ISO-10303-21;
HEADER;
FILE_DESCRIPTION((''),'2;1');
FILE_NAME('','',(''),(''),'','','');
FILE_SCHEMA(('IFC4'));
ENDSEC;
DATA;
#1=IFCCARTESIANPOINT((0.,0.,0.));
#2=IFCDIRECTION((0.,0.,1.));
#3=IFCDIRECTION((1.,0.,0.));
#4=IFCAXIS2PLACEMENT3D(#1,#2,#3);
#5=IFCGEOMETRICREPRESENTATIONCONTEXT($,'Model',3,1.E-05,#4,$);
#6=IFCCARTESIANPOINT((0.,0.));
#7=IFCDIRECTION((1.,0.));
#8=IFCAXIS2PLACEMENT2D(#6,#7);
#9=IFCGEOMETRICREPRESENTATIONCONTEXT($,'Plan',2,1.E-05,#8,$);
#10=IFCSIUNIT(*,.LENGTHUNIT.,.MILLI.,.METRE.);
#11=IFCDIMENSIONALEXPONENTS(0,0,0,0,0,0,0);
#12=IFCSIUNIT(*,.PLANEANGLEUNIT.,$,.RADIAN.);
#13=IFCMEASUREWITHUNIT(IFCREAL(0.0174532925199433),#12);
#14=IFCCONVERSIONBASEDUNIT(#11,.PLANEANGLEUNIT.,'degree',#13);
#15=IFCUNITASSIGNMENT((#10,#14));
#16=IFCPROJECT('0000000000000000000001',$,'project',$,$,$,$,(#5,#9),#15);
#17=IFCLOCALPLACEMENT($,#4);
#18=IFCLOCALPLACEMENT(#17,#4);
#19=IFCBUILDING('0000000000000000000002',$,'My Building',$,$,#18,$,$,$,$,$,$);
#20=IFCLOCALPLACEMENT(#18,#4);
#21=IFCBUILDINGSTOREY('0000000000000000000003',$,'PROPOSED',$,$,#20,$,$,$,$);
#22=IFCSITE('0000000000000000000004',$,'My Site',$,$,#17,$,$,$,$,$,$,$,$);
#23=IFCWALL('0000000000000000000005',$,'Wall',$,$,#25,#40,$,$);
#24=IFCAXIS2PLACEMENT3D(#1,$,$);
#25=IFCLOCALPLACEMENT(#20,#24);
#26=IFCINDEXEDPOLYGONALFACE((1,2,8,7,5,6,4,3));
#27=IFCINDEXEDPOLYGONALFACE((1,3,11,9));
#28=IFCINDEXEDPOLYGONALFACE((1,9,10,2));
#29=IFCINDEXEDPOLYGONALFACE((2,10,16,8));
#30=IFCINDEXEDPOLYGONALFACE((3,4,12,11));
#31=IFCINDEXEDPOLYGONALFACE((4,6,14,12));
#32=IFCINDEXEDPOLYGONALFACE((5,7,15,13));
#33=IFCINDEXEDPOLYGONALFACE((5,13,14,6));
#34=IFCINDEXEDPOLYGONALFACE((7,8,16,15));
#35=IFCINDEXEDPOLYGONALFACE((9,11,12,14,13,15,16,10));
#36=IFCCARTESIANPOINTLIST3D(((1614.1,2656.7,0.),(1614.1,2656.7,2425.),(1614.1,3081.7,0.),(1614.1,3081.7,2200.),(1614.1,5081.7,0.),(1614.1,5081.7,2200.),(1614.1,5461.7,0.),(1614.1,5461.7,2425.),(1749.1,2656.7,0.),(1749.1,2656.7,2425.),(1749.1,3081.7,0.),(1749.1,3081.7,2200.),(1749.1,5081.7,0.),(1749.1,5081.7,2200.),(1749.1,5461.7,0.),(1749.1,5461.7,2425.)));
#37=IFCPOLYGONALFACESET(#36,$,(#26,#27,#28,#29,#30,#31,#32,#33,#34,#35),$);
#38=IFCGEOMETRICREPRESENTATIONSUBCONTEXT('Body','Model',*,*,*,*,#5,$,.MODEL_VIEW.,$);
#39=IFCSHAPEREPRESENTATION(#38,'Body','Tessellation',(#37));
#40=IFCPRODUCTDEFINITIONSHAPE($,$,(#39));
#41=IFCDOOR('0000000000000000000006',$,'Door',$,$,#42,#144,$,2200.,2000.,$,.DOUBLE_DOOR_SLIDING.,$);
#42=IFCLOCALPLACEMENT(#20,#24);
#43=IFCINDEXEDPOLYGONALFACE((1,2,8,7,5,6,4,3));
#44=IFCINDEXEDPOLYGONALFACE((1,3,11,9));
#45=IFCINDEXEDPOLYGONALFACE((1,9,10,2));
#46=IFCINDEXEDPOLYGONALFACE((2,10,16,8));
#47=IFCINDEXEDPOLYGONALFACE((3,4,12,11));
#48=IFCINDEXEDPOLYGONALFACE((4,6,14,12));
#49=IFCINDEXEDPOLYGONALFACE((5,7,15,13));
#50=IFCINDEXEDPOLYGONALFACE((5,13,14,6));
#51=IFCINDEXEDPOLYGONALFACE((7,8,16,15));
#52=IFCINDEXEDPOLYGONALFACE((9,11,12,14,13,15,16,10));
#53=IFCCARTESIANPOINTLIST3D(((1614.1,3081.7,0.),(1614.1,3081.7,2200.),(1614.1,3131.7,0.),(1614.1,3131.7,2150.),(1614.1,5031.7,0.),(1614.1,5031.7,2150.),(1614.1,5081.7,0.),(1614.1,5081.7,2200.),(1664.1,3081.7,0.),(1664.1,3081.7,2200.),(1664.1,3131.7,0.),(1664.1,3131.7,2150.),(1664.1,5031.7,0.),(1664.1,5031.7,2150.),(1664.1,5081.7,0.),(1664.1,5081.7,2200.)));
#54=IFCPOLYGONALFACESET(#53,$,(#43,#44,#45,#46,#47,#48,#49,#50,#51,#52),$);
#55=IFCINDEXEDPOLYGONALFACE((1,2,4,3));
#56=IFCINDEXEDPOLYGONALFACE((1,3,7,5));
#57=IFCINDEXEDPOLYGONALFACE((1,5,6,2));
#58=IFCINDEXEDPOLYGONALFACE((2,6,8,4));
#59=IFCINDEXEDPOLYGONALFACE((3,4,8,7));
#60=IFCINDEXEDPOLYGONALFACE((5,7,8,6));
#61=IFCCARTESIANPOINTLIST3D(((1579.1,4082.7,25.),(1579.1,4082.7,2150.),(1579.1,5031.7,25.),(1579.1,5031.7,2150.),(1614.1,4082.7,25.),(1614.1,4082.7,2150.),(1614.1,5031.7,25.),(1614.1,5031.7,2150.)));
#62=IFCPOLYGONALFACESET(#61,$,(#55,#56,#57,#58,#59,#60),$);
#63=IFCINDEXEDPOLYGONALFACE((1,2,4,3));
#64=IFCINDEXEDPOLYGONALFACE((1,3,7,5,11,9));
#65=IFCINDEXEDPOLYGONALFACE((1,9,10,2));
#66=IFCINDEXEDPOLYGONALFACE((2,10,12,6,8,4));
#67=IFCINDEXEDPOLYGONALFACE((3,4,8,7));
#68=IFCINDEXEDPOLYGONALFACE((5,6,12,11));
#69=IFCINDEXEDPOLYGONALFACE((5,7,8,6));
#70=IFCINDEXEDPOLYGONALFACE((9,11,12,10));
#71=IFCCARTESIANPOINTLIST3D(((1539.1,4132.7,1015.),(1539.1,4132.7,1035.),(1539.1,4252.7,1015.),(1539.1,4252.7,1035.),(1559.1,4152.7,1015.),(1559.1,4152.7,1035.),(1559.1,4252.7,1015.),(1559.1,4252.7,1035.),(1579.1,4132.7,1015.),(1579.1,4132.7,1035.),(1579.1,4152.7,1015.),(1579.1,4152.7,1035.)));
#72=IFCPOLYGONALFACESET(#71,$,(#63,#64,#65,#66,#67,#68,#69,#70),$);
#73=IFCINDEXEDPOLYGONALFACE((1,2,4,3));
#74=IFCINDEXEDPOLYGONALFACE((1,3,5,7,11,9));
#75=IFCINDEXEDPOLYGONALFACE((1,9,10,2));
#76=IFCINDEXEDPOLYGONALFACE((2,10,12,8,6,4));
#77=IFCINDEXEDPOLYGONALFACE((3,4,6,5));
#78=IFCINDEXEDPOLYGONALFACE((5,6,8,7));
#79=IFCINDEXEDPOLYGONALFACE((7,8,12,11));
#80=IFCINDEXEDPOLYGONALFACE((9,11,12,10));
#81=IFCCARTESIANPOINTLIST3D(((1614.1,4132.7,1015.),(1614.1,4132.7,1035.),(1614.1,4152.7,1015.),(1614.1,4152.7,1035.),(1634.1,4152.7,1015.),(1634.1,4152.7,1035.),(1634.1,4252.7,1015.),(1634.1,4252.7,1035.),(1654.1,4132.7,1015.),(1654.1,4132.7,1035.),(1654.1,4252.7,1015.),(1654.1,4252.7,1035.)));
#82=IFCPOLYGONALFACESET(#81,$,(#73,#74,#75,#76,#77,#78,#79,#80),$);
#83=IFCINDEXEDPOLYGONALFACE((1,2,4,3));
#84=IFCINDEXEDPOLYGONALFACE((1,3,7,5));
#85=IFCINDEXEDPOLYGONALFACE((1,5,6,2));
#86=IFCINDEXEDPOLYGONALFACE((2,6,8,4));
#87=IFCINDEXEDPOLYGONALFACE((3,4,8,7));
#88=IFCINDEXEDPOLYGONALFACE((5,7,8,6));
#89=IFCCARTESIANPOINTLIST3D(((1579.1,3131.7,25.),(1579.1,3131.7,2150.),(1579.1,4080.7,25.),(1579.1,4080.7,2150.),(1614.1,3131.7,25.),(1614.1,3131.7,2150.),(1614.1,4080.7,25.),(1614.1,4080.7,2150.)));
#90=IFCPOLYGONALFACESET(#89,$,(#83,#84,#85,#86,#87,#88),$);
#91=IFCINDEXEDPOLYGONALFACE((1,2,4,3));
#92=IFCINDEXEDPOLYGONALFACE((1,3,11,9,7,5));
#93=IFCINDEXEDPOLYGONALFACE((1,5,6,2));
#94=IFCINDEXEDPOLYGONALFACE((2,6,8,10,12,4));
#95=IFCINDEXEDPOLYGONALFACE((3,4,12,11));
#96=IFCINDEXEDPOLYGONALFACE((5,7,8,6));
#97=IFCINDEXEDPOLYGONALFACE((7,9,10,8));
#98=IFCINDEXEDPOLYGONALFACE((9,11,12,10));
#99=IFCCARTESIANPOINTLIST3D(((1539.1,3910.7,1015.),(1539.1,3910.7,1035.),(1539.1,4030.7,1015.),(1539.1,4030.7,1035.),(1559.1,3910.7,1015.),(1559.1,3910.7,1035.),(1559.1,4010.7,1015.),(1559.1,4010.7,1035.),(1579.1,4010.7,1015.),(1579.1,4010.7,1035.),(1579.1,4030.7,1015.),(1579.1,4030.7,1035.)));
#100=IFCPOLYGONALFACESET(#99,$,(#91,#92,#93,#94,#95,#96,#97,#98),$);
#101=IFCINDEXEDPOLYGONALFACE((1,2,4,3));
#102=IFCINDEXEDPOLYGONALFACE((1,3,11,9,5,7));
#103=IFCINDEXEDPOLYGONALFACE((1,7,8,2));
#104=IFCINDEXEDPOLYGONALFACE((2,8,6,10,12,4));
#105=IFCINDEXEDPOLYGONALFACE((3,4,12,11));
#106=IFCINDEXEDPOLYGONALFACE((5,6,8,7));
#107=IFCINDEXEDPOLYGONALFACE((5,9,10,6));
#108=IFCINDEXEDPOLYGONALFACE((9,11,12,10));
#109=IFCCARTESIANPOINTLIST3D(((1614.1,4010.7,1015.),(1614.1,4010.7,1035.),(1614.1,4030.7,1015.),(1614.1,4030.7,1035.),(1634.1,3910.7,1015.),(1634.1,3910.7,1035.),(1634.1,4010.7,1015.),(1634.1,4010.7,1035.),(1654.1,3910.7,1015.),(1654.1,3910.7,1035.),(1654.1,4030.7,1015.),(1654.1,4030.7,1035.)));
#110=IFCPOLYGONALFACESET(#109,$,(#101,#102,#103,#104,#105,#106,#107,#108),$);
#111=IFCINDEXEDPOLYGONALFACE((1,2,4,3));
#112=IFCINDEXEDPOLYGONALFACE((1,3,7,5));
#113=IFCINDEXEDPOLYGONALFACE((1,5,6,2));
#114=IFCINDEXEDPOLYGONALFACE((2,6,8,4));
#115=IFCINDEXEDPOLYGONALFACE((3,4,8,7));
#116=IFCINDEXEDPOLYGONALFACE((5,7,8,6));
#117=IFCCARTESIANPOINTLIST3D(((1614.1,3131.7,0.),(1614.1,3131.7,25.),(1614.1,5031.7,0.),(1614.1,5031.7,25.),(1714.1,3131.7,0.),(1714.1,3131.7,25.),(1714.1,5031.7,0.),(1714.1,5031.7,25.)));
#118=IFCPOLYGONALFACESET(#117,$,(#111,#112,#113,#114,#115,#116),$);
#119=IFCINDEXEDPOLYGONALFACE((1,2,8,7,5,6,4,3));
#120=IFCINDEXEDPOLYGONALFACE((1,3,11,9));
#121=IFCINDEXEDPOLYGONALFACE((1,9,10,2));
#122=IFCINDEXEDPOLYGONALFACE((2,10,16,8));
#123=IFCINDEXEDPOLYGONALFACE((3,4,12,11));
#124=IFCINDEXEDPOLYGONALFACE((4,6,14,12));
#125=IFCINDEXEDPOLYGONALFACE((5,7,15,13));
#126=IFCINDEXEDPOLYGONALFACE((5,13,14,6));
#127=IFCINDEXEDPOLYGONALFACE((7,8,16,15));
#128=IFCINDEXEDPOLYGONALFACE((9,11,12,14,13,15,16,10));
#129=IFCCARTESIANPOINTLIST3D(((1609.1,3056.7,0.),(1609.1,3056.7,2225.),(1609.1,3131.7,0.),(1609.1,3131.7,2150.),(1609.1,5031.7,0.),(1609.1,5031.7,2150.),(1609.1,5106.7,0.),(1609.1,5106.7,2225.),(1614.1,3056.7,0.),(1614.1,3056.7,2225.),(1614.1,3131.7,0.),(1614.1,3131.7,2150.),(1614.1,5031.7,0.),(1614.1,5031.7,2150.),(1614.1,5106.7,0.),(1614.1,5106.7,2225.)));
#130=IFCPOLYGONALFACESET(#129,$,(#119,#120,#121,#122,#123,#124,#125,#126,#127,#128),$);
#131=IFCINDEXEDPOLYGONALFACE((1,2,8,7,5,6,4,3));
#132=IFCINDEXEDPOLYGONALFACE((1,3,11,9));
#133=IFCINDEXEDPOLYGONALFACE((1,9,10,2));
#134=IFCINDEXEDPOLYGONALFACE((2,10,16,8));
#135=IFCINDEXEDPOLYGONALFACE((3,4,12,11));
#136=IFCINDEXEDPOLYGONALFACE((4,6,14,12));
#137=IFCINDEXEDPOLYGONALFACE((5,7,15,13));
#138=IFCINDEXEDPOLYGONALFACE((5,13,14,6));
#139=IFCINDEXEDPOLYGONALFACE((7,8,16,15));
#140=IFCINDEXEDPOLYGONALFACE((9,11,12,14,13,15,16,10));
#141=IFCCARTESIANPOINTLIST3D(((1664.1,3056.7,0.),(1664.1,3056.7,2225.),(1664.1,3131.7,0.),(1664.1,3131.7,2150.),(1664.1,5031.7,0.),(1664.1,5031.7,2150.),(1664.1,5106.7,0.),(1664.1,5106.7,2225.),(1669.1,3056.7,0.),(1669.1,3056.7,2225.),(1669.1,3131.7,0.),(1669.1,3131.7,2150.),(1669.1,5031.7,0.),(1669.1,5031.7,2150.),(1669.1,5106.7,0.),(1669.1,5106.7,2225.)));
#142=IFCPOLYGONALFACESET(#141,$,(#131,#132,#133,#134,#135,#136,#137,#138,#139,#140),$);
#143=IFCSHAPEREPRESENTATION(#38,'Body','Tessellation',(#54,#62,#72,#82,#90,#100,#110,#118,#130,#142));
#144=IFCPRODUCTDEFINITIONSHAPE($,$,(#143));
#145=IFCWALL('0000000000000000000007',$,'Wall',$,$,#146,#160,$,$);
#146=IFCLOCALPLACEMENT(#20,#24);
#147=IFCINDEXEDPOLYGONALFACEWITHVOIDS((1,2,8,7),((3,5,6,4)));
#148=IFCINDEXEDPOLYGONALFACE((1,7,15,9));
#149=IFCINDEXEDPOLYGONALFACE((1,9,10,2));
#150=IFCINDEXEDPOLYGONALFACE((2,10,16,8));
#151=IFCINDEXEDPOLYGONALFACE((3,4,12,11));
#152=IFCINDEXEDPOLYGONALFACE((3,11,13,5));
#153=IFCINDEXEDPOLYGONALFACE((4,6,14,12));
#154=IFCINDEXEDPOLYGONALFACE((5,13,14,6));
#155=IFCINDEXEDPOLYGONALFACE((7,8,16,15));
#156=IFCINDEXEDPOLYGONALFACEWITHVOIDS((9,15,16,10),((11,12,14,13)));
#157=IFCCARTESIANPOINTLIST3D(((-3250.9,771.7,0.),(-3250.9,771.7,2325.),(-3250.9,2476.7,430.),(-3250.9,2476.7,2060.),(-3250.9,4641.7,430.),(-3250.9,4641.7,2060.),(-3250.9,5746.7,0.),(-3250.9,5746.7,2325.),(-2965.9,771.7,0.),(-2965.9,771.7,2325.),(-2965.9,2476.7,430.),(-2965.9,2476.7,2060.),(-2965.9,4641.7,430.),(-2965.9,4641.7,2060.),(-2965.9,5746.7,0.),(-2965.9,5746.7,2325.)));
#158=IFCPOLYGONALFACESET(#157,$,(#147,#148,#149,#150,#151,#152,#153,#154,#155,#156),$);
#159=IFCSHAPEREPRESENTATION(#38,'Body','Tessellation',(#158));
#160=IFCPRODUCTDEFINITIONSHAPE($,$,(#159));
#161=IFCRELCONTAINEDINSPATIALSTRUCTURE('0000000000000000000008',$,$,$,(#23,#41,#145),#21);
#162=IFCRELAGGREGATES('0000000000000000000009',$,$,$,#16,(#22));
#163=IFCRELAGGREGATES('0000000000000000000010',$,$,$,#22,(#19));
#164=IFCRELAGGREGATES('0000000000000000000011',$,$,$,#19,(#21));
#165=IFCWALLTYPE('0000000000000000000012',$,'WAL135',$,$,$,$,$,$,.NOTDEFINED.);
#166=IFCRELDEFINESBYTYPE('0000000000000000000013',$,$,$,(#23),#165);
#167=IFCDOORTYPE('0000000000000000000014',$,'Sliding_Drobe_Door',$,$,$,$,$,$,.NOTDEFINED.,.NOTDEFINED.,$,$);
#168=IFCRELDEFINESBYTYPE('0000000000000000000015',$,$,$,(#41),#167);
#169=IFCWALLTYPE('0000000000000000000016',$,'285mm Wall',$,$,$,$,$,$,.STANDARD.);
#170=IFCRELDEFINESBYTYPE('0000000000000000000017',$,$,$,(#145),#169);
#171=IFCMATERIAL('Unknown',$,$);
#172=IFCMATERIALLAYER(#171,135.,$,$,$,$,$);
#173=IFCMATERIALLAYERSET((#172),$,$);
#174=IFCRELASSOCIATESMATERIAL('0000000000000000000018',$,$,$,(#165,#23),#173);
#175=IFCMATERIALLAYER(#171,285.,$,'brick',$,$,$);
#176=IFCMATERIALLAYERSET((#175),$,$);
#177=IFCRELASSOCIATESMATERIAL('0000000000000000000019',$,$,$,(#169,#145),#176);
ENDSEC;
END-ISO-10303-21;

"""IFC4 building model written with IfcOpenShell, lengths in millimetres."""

from ifc_helpers import new_model, entity, si_unit, converted_unit, frame, origin_with_axes, origin_2d_with_axis, place, context, subcontext, project, spatial, line, indexed_curve, outline, extrude, shape, source, transform, mapped, material, layer, layer_set, layer_usage, type_object, type_shapes, element, fill, save


model = new_model("IFC4")

# Units and contexts
model_context = context("Model", 3, precision=1e-05, world=origin_with_axes())
plan_context = context("Plan", 2, precision=1e-05, world=origin_2d_with_axis())
body_context_1 = subcontext(model_context, "Body", "Model", "MODEL_VIEW")
body_context_2 = subcontext(plan_context, "Body", "Plan", "PLAN_VIEW")
ifc_project = project(units=[si_unit("LENGTHUNIT", "METRE", prefix="MILLI"), converted_unit("PLANEANGLEUNIT", "degree", entity("IfcReal", 0.0174532925199433), si_unit("PLANEANGLEUNIT", "RADIAN"), dimensions=[0, 0, 0, 0, 0, 0, 0])], contexts=[model_context, plan_context])

# Site, building, storey
site_placement = place(None, origin_with_axes())
site = spatial("IfcSite", under=ifc_project, at=site_placement, Name="My Site")
building_placement = place(site_placement, origin_with_axes())
building = spatial("IfcBuilding", under=site, at=building_placement, Name="My Building")
storey_placement = place(building_placement, origin_with_axes())
storey = spatial("IfcBuildingStorey", under=building, at=storey_placement, Name="PROPOSED")

# Shared definitions
ifc_material = material(Name="Unknown")

# Shared definitions
ifc_layer_1 = layer(ifc_material, 135.0)
ifc_layer_set_1 = layer_set([ifc_layer_1])
wall_type_1 = type_object("IfcWallType", Name="WAL135", PredefinedType="NOTDEFINED", material=ifc_layer_set_1)

# Wall, opening, door
ifc_layer_usage_1 = layer_usage(ifc_layer_set_1, "AXIS2", "POSITIVE", 0.0)
wall_1_placement = place(storey_placement, frame((1614.1, 5461.7, 0.0), z_axis=(0.0, 0.0, 1.0), x_axis=(0.0, -1.0, 0.0)))
wall_1 = element("IfcWall", 1, at=wall_1_placement, inside=storey, type_object=wall_type_1, material=ifc_layer_usage_1, Name="Wall", context=body_context_1, shape_type="SweptSolid", body=[
    extrude(outline(indexed_curve([(0.0, 0.0), (0.0, 135.0), (2805.0, 135.0), (2805.0, 0.0), (0.0, 0.0)], self_intersect=False)), origin_with_axes(), (0.0, 0.0, 1.0), 2425.0),
])
shared_shape_1 = source(origin_with_axes(), body_context_1, "Body", "SweptSolid", [
    extrude(outline(indexed_curve([(0.0, 0.0), (2000.0, 0.0), (2000.0, 2200.0), (0.0, 2200.0)], segments=[line(1, 2, 3, 4, 1)])), frame((0.0, -100.0, 0.0), z_axis=(0.0, -1.0, 0.0), x_axis=(1.0, 0.0, 0.0)), (0.0, 0.0, -1.0), 335.0),
])
opening_1_placement = place(wall_1_placement, frame((380.0, 0.0, 0.0), z_axis=(0.0, 0.0, 1.0), x_axis=(1.0, 0.0, 0.0)))
opening_1 = element("IfcOpeningElement", 2, at=opening_1_placement, cuts=wall_1, PredefinedType="OPENING", context=body_context_1, shape_type="MappedRepresentation", body=[
    mapped(shared_shape_1, transform((0.0, 0.0, 0.0), x_axis=(1.0, 0.0, 0.0), y_axis=(0.0, 1.0, 0.0), z_axis=(0.0, 0.0, 1.0), scale=1.0)),
])
door_type = type_object("IfcDoorType", Name="Sliding_Drobe_Door", OperationType="NOTDEFINED", PredefinedType="NOTDEFINED")
shared_shape_2 = source(origin_with_axes(), body_context_1, "Body", "SweptSolid", [
    extrude(outline(indexed_curve([(0.0, 0.0), (0.0, 2200.0), (2000.0, 2200.0), (2000.0, 0.0), (1950.0, 0.0), (1950.0, 2150.0), (50.0, 2150.0), (50.0, 0.0)], segments=[line(1, 2, 3, 4, 5, 6, 7, 8, 1)])), frame((0.0, 0.0, 0.0), z_axis=(0.0, -1.0, 0.0), x_axis=(1.0, 0.0, 0.0)), (0.0, 0.0, -1.0), 50.0),
    extrude(outline(indexed_curve([(0.0, 0.0), (949.0, 0.0), (949.0, 35.0), (0.0, 35.0)], segments=[line(1, 2, 3, 4, 1)])), frame((50.0, -35.0, 25.0), z_axis=(0.0, 0.0, 1.0), x_axis=(1.0, 0.0, 0.0)), (0.0, 0.0, 1.0), 2125.0),
    extrude(outline(indexed_curve([(0.0, 0.0), (0.0, -40.0), (-120.0, -40.0), (-120.0, -20.0), (-20.0, -20.0), (-20.0, 0.0)], segments=[line(1, 2, 3, 4, 5, 6, 1)])), frame((949.0, -35.0, 1015.0), z_axis=(0.0, 0.0, 1.0), x_axis=(1.0, 0.0, 0.0)), (0.0, 0.0, 1.0), 20.0),
    extrude(outline(indexed_curve([(0.0, 0.0), (0.0, 40.0), (-120.0, 40.0), (-120.0, 20.0), (-20.0, 20.0), (-20.0, 0.0)], segments=[line(1, 2, 3, 4, 5, 6, 1)])), frame((949.0, 0.0, 1015.0), z_axis=(0.0, 0.0, 1.0), x_axis=(1.0, 0.0, 0.0)), (0.0, 0.0, 1.0), 20.0),
    extrude(outline(indexed_curve([(0.0, 0.0), (-949.0, 0.0), (-949.0, 35.0), (0.0, 35.0)], segments=[line(1, 2, 3, 4, 1)])), frame((1950.0, -35.0, 25.0), z_axis=(0.0, 0.0, 1.0), x_axis=(1.0, 0.0, 0.0)), (0.0, 0.0, 1.0), 2125.0),
    extrude(outline(indexed_curve([(0.0, 0.0), (0.0, -40.0), (120.0, -40.0), (120.0, -20.0), (20.0, -20.0), (20.0, 0.0)], segments=[line(1, 2, 3, 4, 5, 6, 1)])), frame((1051.0, -35.0, 1015.0), z_axis=(0.0, 0.0, 1.0), x_axis=(1.0, 0.0, 0.0)), (0.0, 0.0, 1.0), 20.0),
    extrude(outline(indexed_curve([(0.0, 0.0), (0.0, 40.0), (120.0, 40.0), (120.0, 20.0), (20.0, 20.0), (20.0, 0.0)], segments=[line(1, 2, 3, 4, 5, 6, 1)])), frame((1051.0, 0.0, 1015.0), z_axis=(0.0, 0.0, 1.0), x_axis=(1.0, 0.0, 0.0)), (0.0, 0.0, 1.0), 20.0),
    extrude(outline(indexed_curve([(0.0, 0.0), (1900.0, 0.0), (1900.0, 100.0), (0.0, 100.0)], segments=[line(1, 2, 3, 4, 1)])), frame((50.0, 0.0, 0.0), z_axis=(0.0, 0.0, 1.0), x_axis=(1.0, 0.0, 0.0)), (0.0, 0.0, 1.0), 25.0),
    extrude(outline(indexed_curve([(0.0, 0.0), (0.0, 2225.0), (2050.0, 2225.0), (2050.0, 0.0), (1975.0, 0.0), (1975.0, 2150.0), (75.0, 2150.0), (75.0, 0.0)], segments=[line(1, 2, 3, 4, 5, 6, 7, 8, 1)])), frame((-25.0, -5.0, 0.0), z_axis=(0.0, -1.0, 0.0), x_axis=(1.0, 0.0, 0.0)), (0.0, 0.0, -1.0), 5.0),
    extrude(outline(indexed_curve([(0.0, 0.0), (0.0, 2225.0), (2050.0, 2225.0), (2050.0, 0.0), (1975.0, 0.0), (1975.0, 2150.0), (75.0, 2150.0), (75.0, 0.0)], segments=[line(1, 2, 3, 4, 5, 6, 7, 8, 1)])), frame((-25.0, 50.0, 0.0), z_axis=(0.0, -1.0, 0.0), x_axis=(1.0, 0.0, 0.0)), (0.0, 0.0, -1.0), 5.0),
])
shared_shape_3 = source(origin_with_axes(), body_context_2, "Body", "Curve2D", [
    entity("IfcIndexedPolyCurve", entity("IfcCartesianPointList2D", [[0.0, 0.0], [50.0, 0.0], [50.0, 50.0], [0.0, 50.0]]), [entity("IfcLineIndex", [1, 2, 3, 4, 1])]),
    entity("IfcIndexedPolyCurve", entity("IfcCartesianPointList2D", [[2000.0, 0.0], [1950.0, 0.0], [1950.0, 50.0], [2000.0, 50.0]]), [entity("IfcLineIndex", [1, 2, 3, 4, 1])]),
    entity("IfcIndexedPolyCurve", entity("IfcCartesianPointList2D", [[-425.0, -35.0], [525.0, -35.0], [525.0, 0.0], [-425.0, 0.0]]), [entity("IfcLineIndex", [1, 2, 3, 4, 1])]),
    entity("IfcIndexedPolyCurve", entity("IfcCartesianPointList2D", [[2425.0, -35.0], [1475.0, -35.0], [1475.0, 0.0], [2425.0, 0.0]]), [entity("IfcLineIndex", [1, 2, 3, 4, 1])]),
])
type_shapes(door_type, [shared_shape_2, shared_shape_3])
door_placement = place(opening_1_placement, frame((0.0, 0.0, 0.0), z_axis=(0.0, 0.0, 1.0), x_axis=(1.0, 0.0, 0.0)))
door = element("IfcDoor", 3, at=door_placement, inside=storey, type_object=door_type, Name="Door", OperationType="DOUBLE_DOOR_SLIDING", OverallHeight=2200.0, OverallWidth=2000.0, shapes=[
    shape(body_context_1, "Body", "MappedRepresentation", [mapped(shared_shape_2, transform((0.0, 0.0, 0.0), x_axis=(1.0, 0.0, 0.0), y_axis=(0.0, 1.0, 0.0), z_axis=(0.0, 0.0, 1.0), scale=1.0))]),
    shape(body_context_2, "Body", "MappedRepresentation", [mapped(shared_shape_3, transform((0.0, 0.0, 0.0), x_axis=(1.0, 0.0, 0.0), y_axis=(0.0, 1.0, 0.0), z_axis=(0.0, 0.0, 1.0), scale=1.0))]),
])
fill(opening_1, door)

# Wall, opening
ifc_layer_2 = layer(ifc_material, 285.0, Name="brick")
ifc_layer_set_2 = layer_set([ifc_layer_2])
ifc_layer_usage_2 = layer_usage(ifc_layer_set_2, "AXIS2", "POSITIVE", 0.0)
wall_type_2 = type_object("IfcWallType", Name="285mm Wall", PredefinedType="STANDARD", material=ifc_layer_set_2)
wall_2_placement = place(storey_placement, frame((-3250.9, 5746.7, 0.0), z_axis=(0.0, 0.0, 1.0), x_axis=(0.0, -1.0, 0.0)))
wall_2 = element("IfcWall", 4, at=wall_2_placement, inside=storey, type_object=wall_type_2, material=ifc_layer_usage_2, Name="Wall", context=body_context_1, shape_type="SweptSolid", body=[
    extrude(outline(indexed_curve([(0.0, 0.0), (0.0, 285.0), (4975.0, 285.0), (4975.0, 0.0), (0.0, 0.0)], self_intersect=False)), origin_with_axes(), (0.0, 0.0, 1.0), 2325.0),
])
shared_shape_4 = source(origin_with_axes(), body_context_1, "Body", "SweptSolid", [
    extrude(outline(indexed_curve([(0.0, 0.0), (2165.0, 0.0), (2165.0, 1630.0), (0.0, 1630.0)], segments=[line(1, 2, 3, 4, 1)])), frame((0.0, -600.0, 0.0), z_axis=(0.0, -1.0, 0.0), x_axis=(1.0, 0.0, 0.0)), (0.0, 0.0, -1.0), 1200.0),
])
opening_2_placement = place(wall_2_placement, frame((3270.0, 51.1, 430.0), z_axis=(0.0, 0.0, 1.0), x_axis=(-1.0, 0.0, 0.0)))
element("IfcOpeningElement", 5, at=opening_2_placement, cuts=wall_2, PredefinedType="OPENING", context=body_context_1, shape_type="MappedRepresentation", body=[
    mapped(shared_shape_4, transform((0.0, 0.0, 0.0), x_axis=(1.0, 0.0, 0.0), y_axis=(0.0, 1.0, 0.0), z_axis=(0.0, 0.0, 1.0), scale=1.0)),
])

save(model, "model.ifc")
